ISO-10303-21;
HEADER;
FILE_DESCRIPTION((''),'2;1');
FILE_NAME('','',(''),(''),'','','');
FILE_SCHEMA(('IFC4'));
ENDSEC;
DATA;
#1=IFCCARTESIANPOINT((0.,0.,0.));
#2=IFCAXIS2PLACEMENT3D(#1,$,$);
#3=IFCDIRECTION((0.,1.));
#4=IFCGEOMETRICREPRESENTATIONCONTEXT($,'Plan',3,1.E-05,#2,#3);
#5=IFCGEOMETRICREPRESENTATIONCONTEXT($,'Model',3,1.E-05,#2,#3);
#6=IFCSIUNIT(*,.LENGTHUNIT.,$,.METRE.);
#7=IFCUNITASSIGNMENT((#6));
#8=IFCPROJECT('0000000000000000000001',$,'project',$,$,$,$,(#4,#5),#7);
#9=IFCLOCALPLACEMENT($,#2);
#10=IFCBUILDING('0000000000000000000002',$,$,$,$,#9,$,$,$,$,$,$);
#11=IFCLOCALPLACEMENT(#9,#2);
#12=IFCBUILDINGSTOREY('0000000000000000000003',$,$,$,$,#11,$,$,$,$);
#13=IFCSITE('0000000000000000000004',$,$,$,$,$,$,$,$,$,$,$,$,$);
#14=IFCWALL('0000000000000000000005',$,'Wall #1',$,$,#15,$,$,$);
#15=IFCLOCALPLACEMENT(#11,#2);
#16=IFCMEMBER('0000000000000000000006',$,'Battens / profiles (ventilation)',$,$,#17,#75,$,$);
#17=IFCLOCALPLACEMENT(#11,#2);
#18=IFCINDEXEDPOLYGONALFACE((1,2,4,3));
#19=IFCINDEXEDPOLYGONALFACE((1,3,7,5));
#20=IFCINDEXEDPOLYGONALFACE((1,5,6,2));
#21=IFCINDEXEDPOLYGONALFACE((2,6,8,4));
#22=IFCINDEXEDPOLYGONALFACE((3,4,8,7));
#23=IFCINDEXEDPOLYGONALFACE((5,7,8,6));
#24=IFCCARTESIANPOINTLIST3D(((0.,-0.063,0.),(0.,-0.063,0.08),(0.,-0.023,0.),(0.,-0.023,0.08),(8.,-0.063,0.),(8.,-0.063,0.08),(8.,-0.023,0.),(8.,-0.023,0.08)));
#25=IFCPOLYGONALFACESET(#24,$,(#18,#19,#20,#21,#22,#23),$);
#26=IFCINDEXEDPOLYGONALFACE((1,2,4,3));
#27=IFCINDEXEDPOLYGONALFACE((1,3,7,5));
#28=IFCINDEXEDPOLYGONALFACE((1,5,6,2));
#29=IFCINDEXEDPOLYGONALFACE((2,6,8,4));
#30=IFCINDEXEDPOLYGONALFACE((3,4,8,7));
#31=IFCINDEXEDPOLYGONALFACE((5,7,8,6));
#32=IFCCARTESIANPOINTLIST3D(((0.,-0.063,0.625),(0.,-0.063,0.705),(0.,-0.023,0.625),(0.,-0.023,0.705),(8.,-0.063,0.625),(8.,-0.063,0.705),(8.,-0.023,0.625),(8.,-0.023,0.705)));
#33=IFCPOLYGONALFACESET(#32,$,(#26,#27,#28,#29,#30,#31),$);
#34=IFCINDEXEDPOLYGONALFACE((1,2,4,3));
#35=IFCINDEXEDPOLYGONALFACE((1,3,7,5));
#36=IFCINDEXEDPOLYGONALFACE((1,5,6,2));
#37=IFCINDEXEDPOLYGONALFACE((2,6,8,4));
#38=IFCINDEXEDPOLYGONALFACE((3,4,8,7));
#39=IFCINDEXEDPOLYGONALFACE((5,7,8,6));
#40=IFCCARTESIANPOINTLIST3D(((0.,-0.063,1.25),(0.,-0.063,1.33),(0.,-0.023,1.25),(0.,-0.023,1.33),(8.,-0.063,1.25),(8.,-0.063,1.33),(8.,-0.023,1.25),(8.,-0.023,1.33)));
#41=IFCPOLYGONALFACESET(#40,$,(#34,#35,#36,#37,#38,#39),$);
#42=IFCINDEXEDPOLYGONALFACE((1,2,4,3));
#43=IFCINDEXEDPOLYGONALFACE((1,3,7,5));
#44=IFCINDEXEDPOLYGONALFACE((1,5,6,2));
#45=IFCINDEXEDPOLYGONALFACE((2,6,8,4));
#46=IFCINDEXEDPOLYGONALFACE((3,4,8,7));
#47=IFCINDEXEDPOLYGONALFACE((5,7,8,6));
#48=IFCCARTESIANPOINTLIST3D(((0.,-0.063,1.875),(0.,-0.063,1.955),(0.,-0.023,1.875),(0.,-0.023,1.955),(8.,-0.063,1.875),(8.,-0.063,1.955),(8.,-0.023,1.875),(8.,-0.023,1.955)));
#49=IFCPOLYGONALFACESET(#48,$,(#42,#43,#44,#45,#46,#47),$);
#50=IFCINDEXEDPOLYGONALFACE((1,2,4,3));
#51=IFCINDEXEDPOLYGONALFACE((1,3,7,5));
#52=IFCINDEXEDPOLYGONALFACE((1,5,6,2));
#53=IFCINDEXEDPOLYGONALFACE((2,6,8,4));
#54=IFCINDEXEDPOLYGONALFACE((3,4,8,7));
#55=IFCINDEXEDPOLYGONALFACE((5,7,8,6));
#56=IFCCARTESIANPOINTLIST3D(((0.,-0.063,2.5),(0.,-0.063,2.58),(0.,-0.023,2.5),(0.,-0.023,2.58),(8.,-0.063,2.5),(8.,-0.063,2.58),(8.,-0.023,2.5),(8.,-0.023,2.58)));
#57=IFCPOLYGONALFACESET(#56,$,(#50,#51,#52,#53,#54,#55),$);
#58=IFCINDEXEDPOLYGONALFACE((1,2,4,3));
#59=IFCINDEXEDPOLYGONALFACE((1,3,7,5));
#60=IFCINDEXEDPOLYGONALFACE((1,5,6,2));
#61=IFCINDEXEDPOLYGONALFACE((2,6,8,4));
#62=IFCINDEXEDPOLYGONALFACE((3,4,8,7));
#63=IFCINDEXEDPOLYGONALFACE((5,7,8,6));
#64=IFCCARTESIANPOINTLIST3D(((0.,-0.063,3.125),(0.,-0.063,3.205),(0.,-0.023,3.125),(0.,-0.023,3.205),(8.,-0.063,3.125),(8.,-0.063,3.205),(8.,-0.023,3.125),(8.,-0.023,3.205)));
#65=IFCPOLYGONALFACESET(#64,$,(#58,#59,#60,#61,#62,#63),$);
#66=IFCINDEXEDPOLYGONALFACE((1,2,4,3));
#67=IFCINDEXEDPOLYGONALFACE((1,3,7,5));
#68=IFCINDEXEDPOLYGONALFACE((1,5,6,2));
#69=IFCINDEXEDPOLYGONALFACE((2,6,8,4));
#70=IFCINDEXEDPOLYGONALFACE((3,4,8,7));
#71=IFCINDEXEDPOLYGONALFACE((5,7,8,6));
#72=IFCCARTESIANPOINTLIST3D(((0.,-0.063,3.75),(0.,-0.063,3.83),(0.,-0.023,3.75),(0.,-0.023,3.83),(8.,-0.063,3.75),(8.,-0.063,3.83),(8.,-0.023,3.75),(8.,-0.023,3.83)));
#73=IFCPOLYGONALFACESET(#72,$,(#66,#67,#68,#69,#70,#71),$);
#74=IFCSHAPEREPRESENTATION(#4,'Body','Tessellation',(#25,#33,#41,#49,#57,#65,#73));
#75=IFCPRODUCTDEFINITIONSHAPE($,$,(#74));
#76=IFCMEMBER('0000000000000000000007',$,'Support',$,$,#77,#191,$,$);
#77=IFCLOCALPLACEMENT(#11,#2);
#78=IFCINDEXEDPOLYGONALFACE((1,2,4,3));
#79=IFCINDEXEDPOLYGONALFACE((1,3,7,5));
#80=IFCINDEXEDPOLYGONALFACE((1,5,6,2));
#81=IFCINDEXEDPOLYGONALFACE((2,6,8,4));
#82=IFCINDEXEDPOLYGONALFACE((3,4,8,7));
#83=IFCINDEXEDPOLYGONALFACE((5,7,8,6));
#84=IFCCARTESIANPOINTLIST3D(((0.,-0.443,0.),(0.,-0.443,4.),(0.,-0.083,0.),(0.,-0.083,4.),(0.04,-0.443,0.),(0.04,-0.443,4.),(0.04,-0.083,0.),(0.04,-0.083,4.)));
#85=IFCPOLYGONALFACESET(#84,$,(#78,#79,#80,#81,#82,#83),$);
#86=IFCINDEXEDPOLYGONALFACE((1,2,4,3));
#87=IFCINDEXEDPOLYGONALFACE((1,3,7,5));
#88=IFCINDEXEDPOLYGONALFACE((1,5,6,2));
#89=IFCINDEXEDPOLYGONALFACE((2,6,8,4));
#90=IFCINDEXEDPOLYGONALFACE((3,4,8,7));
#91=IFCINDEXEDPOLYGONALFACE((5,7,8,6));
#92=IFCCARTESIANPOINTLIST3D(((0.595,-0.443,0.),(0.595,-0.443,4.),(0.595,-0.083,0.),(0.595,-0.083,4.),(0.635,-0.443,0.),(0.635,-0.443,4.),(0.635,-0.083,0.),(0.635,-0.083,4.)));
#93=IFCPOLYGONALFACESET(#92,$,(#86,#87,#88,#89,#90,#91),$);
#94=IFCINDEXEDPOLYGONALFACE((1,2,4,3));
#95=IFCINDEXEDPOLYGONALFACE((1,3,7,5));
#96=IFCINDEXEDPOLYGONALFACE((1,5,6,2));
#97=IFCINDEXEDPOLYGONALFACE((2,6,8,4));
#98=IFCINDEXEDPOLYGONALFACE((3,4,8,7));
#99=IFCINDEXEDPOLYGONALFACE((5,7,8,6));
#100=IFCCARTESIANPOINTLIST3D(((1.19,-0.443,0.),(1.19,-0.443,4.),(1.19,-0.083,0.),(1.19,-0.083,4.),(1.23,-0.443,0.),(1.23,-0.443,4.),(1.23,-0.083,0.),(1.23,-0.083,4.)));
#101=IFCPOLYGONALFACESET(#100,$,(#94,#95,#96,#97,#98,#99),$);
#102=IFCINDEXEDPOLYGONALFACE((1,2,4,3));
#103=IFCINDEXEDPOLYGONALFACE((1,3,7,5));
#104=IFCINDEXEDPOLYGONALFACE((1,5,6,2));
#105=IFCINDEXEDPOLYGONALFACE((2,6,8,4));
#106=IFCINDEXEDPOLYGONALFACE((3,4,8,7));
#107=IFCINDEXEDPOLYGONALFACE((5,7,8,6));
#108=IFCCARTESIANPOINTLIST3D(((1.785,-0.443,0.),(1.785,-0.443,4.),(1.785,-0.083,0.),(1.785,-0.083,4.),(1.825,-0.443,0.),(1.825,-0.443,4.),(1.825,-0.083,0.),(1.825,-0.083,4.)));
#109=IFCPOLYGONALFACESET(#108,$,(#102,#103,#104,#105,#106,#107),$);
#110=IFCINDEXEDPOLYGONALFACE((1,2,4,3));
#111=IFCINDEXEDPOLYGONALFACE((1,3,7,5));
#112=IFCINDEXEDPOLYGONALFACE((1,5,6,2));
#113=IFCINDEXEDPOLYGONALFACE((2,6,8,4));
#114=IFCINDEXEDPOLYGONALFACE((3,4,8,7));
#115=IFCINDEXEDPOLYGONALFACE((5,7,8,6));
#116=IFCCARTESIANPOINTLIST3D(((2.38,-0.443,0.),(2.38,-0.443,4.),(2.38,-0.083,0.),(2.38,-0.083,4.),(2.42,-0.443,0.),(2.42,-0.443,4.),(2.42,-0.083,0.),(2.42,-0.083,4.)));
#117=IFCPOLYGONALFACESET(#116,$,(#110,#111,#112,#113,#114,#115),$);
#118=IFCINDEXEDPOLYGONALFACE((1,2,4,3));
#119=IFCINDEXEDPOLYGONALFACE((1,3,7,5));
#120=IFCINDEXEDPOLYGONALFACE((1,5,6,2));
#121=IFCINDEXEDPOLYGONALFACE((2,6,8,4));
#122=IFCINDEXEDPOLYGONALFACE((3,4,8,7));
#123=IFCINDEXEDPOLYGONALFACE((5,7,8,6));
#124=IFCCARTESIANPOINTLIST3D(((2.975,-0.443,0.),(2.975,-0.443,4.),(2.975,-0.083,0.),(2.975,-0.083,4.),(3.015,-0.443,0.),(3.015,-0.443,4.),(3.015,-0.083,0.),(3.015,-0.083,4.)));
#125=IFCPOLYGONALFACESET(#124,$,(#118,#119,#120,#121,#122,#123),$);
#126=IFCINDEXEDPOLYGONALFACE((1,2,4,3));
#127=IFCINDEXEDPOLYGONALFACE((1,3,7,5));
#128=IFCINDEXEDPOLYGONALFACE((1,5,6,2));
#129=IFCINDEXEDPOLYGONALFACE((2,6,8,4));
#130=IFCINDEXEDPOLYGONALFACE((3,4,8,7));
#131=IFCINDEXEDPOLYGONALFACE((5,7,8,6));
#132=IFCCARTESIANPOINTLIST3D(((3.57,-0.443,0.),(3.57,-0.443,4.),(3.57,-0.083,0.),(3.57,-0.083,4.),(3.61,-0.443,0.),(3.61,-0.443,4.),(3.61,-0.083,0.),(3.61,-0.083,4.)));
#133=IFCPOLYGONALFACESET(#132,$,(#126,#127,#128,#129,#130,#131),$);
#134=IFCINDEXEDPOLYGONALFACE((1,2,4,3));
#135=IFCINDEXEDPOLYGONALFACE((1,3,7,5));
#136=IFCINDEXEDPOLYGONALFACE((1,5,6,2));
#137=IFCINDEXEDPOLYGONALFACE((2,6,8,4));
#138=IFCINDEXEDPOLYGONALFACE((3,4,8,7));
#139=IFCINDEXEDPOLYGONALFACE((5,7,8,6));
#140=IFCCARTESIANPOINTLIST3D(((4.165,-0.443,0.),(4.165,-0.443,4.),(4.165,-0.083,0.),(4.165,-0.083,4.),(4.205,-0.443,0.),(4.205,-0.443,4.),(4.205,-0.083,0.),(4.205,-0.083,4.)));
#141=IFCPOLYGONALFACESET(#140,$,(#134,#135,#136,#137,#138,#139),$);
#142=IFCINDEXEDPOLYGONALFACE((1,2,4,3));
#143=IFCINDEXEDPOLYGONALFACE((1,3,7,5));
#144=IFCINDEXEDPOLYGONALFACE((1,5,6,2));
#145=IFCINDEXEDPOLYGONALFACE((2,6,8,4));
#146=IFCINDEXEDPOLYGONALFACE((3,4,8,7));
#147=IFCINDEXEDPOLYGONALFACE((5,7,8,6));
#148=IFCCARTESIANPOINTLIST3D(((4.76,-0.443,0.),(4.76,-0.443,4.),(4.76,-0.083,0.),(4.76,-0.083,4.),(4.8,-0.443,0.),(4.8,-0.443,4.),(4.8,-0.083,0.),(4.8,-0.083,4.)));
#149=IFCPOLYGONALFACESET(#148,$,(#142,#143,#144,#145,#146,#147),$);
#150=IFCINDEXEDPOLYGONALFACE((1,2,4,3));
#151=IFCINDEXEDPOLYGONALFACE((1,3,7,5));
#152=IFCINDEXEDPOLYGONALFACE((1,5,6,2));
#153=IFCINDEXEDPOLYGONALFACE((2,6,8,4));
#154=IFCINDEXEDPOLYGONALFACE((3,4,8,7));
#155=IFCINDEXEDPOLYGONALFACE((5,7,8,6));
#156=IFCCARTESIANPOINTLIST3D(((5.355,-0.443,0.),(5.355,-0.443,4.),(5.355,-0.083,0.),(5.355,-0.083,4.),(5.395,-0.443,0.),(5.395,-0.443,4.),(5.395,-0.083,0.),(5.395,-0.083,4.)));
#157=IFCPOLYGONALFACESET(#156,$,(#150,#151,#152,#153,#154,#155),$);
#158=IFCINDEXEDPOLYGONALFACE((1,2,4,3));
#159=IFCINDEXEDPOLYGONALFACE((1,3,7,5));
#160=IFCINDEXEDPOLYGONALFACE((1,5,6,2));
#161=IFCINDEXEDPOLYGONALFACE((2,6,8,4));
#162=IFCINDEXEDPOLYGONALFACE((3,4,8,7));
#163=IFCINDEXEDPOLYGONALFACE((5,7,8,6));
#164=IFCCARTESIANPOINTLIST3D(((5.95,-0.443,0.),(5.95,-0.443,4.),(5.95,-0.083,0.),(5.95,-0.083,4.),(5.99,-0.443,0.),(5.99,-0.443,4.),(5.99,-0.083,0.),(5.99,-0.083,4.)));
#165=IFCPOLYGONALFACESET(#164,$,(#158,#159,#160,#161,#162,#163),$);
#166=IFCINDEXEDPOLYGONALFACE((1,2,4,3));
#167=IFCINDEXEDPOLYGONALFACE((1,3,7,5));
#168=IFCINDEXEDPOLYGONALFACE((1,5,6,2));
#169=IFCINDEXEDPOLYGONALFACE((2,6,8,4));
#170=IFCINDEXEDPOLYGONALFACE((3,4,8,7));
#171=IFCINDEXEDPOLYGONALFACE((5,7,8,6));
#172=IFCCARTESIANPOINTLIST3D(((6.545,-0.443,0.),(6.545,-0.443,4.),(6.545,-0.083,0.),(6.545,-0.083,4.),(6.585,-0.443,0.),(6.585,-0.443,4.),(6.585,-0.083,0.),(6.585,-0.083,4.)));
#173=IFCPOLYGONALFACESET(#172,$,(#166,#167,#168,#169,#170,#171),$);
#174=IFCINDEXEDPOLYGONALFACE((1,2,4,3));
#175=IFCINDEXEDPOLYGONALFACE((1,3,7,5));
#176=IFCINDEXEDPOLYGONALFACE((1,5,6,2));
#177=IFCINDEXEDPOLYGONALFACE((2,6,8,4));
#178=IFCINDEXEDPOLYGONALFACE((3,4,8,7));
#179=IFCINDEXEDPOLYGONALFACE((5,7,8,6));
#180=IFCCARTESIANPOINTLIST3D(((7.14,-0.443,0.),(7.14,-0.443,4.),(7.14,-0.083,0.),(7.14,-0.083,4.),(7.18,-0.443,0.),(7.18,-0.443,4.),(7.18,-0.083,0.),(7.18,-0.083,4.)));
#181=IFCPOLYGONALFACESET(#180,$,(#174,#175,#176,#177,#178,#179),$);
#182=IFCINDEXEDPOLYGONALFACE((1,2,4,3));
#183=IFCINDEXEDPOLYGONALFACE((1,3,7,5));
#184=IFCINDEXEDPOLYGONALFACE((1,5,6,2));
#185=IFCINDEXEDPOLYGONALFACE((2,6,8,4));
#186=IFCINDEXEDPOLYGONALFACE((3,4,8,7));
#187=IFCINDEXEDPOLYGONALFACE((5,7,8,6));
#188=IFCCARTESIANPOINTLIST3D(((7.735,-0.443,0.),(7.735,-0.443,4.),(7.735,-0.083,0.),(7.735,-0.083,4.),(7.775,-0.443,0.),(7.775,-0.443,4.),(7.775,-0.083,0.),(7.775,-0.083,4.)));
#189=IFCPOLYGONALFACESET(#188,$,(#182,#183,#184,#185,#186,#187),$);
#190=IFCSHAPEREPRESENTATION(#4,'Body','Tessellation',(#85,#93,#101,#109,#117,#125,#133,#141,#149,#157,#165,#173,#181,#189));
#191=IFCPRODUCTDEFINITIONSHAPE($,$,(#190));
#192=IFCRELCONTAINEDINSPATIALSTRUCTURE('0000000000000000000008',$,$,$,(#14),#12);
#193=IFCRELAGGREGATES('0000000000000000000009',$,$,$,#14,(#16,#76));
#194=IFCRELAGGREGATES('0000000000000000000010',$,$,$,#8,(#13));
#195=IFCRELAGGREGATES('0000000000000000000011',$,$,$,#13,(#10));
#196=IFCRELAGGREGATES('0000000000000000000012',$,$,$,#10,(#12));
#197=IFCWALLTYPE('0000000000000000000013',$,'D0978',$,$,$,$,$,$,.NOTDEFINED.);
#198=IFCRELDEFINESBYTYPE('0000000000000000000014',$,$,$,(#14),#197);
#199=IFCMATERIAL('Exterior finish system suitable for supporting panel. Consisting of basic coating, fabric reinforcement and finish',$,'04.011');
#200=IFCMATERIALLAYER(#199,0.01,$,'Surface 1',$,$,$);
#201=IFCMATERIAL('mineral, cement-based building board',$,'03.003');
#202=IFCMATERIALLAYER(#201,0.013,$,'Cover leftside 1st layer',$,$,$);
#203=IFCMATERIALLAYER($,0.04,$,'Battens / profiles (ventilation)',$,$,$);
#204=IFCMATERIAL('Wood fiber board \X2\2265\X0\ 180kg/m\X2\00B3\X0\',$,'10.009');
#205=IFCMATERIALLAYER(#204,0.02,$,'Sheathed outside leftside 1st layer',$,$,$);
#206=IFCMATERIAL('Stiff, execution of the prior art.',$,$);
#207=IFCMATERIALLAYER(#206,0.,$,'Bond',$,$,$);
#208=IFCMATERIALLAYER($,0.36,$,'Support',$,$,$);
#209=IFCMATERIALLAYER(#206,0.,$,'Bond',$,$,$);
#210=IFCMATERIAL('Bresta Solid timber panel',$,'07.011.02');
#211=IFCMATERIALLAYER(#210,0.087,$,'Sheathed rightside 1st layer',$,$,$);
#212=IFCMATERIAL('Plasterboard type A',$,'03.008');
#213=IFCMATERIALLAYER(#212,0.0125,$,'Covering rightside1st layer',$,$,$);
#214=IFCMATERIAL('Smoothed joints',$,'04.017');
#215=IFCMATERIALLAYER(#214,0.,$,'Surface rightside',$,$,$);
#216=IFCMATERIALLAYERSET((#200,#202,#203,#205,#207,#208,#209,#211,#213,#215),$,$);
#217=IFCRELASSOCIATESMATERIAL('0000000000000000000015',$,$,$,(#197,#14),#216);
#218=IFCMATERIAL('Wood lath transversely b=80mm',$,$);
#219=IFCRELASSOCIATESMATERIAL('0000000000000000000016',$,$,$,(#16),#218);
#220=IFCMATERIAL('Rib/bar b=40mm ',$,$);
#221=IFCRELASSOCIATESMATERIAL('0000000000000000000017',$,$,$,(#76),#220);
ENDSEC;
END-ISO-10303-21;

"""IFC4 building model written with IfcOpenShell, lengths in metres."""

from ifc_helpers import new_model, si_unit, direction, frame, frame_2d, origin, place, context, project, spatial, rectangle, extrude, material, layer, layer_set, type_object, element, aggregate, save


model = new_model("IFC4")

# Units and contexts
plan_context = context("Plan", 3, precision=1e-05, world=origin(), true_north=direction((0.0, 1.0)))
model_context = context("Model", 3, precision=1e-05, world=origin(), true_north=direction((0.0, 1.0)))
ifc_project = project(units=[si_unit("LENGTHUNIT", "METRE")], contexts=[plan_context, model_context])

# Site, building, storey
site = spatial("IfcSite", under=ifc_project)
building_placement = place(None, origin())
building = spatial("IfcBuilding", under=site, at=building_placement)
storey_placement = place(building_placement, origin())
storey = spatial("IfcBuildingStorey", under=building, at=storey_placement)

# Wall, members
ifc_material_1 = material(Name="Exterior finish system suitable for supporting panel. Consisting of basic coating, fabric reinforcement and finish", Category="04.011")
ifc_layer_1 = layer(ifc_material_1, 0.01, Name="Surface 1")
ifc_material_2 = material(Name="mineral, cement-based building board", Category="03.003")
ifc_layer_2 = layer(ifc_material_2, 0.013, Name="Cover leftside 1st layer")
ifc_layer_3 = layer(None, 0.04, Name="Battens / profiles (ventilation)")
ifc_material_3 = material(Name="Wood fiber board ≥ 180kg/m³", Category="10.009")
ifc_layer_4 = layer(ifc_material_3, 0.02, Name="Sheathed outside leftside 1st layer")
ifc_material_4 = material(Name="Stiff, execution of the prior art.")
ifc_layer_5 = layer(ifc_material_4, 0.0, Name="Bond")
ifc_layer_6 = layer(None, 0.36, Name="Support")
ifc_layer_7 = layer(ifc_material_4, 0.0, Name="Bond")
ifc_material_5 = material(Name="Bresta Solid timber panel", Category="07.011.02")
ifc_layer_8 = layer(ifc_material_5, 0.087, Name="Sheathed rightside 1st layer")
ifc_material_6 = material(Name="Plasterboard type A", Category="03.008")
ifc_layer_9 = layer(ifc_material_6, 0.0125, Name="Covering rightside1st layer")
ifc_material_7 = material(Name="Smoothed joints", Category="04.017")
ifc_layer_10 = layer(ifc_material_7, 0.0, Name="Surface rightside")
ifc_layer_set = layer_set([ifc_layer_1, ifc_layer_2, ifc_layer_3, ifc_layer_4, ifc_layer_5, ifc_layer_6, ifc_layer_7, ifc_layer_8, ifc_layer_9, ifc_layer_10])
wall_type = type_object("IfcWallType", Name="D0978", PredefinedType="NOTDEFINED", material=ifc_layer_set)
wall_placement = place(None, frame((0.0, 0.0, 0.0), z_axis=(0.0, -1.0, 0.0), x_axis=(1.0, 0.0, 0.0)))
wall = element("IfcWall", 1, at=wall_placement, inside=storey, type_object=wall_type, material=ifc_layer_set, Name="Wall #1")
ifc_material_8 = material(Name="Wood lath transversely b=80mm")
member_1_placement = place(wall_placement, origin())
member_1 = element("IfcMember", 2, at=member_1_placement, material=ifc_material_8, Name="Battens / profiles (ventilation)", context=plan_context, shape_type="SweptSolid", body=[
    extrude(rectangle(XDim=0.08, YDim=0.04, at=frame_2d((0.04, 0.02), x_axis=(1.0, 0.0))), frame((0.0, 0.0, 0.023), z_axis=(1.0, 0.0, 0.0), x_axis=(0.0, 1.0, 0.0)), (0.0, 0.0, 1.0), 8.0),
    extrude(rectangle(XDim=0.08, YDim=0.04, at=frame_2d((0.04, 0.02), x_axis=(1.0, 0.0))), frame((0.0, 0.625, 0.023), z_axis=(1.0, 0.0, 0.0), x_axis=(0.0, 1.0, 0.0)), (0.0, 0.0, 1.0), 8.0),
    extrude(rectangle(XDim=0.08, YDim=0.04, at=frame_2d((0.04, 0.02), x_axis=(1.0, 0.0))), frame((0.0, 1.25, 0.023), z_axis=(1.0, 0.0, 0.0), x_axis=(0.0, 1.0, 0.0)), (0.0, 0.0, 1.0), 8.0),
    extrude(rectangle(XDim=0.08, YDim=0.04, at=frame_2d((0.04, 0.02), x_axis=(1.0, 0.0))), frame((0.0, 1.875, 0.023), z_axis=(1.0, 0.0, 0.0), x_axis=(0.0, 1.0, 0.0)), (0.0, 0.0, 1.0), 8.0),
    extrude(rectangle(XDim=0.08, YDim=0.04, at=frame_2d((0.04, 0.02), x_axis=(1.0, 0.0))), frame((0.0, 2.5, 0.023), z_axis=(1.0, 0.0, 0.0), x_axis=(0.0, 1.0, 0.0)), (0.0, 0.0, 1.0), 8.0),
    extrude(rectangle(XDim=0.08, YDim=0.04, at=frame_2d((0.04, 0.02), x_axis=(1.0, 0.0))), frame((0.0, 3.125, 0.023), z_axis=(1.0, 0.0, 0.0), x_axis=(0.0, 1.0, 0.0)), (0.0, 0.0, 1.0), 8.0),
    extrude(rectangle(XDim=0.08, YDim=0.04, at=frame_2d((0.04, 0.02), x_axis=(1.0, 0.0))), frame((0.0, 3.75, 0.023), z_axis=(1.0, 0.0, 0.0), x_axis=(0.0, 1.0, 0.0)), (0.0, 0.0, 1.0), 8.0),
])
ifc_material_9 = material(Name="Rib/bar b=40mm ")
member_2_placement = place(wall_placement, origin())
member_2 = element("IfcMember", 3, at=member_2_placement, material=ifc_material_9, Name="Support", context=plan_context, shape_type="SweptSolid", body=[
    extrude(rectangle(XDim=0.04, YDim=0.36, at=frame_2d((0.02, 0.18), x_axis=(1.0, 0.0))), frame((0.0, 4.0, 0.083), z_axis=(0.0, -1.0, 0.0), x_axis=(1.0, 0.0, 0.0)), (0.0, 0.0, 1.0), 4.0),
    extrude(rectangle(XDim=0.04, YDim=0.36, at=frame_2d((0.02, 0.18), x_axis=(1.0, 0.0))), frame((0.595, 4.0, 0.083), z_axis=(0.0, -1.0, 0.0), x_axis=(1.0, 0.0, 0.0)), (0.0, 0.0, 1.0), 4.0),
    extrude(rectangle(XDim=0.04, YDim=0.36, at=frame_2d((0.02, 0.18), x_axis=(1.0, 0.0))), frame((1.19, 4.0, 0.083), z_axis=(0.0, -1.0, 0.0), x_axis=(1.0, 0.0, 0.0)), (0.0, 0.0, 1.0), 4.0),
    extrude(rectangle(XDim=0.04, YDim=0.36, at=frame_2d((0.02, 0.18), x_axis=(1.0, 0.0))), frame((1.785, 4.0, 0.083), z_axis=(0.0, -1.0, 0.0), x_axis=(1.0, 0.0, 0.0)), (0.0, 0.0, 1.0), 4.0),
    extrude(rectangle(XDim=0.04, YDim=0.36, at=frame_2d((0.02, 0.18), x_axis=(1.0, 0.0))), frame((2.38, 4.0, 0.083), z_axis=(0.0, -1.0, 0.0), x_axis=(1.0, 0.0, 0.0)), (0.0, 0.0, 1.0), 4.0),
    extrude(rectangle(XDim=0.04, YDim=0.36, at=frame_2d((0.02, 0.18), x_axis=(1.0, 0.0))), frame((2.975, 4.0, 0.083), z_axis=(0.0, -1.0, 0.0), x_axis=(1.0, 0.0, 0.0)), (0.0, 0.0, 1.0), 4.0),
    extrude(rectangle(XDim=0.04, YDim=0.36, at=frame_2d((0.02, 0.18), x_axis=(1.0, 0.0))), frame((3.57, 4.0, 0.083), z_axis=(0.0, -1.0, 0.0), x_axis=(1.0, 0.0, 0.0)), (0.0, 0.0, 1.0), 4.0),
    extrude(rectangle(XDim=0.04, YDim=0.36, at=frame_2d((0.02, 0.18), x_axis=(1.0, 0.0))), frame((4.165, 4.0, 0.083), z_axis=(0.0, -1.0, 0.0), x_axis=(1.0, 0.0, 0.0)), (0.0, 0.0, 1.0), 4.0),
    extrude(rectangle(XDim=0.04, YDim=0.36, at=frame_2d((0.02, 0.18), x_axis=(1.0, 0.0))), frame((4.76, 4.0, 0.083), z_axis=(0.0, -1.0, 0.0), x_axis=(1.0, 0.0, 0.0)), (0.0, 0.0, 1.0), 4.0),
    extrude(rectangle(XDim=0.04, YDim=0.36, at=frame_2d((0.02, 0.18), x_axis=(1.0, 0.0))), frame((5.355, 4.0, 0.083), z_axis=(0.0, -1.0, 0.0), x_axis=(1.0, 0.0, 0.0)), (0.0, 0.0, 1.0), 4.0),
    extrude(rectangle(XDim=0.04, YDim=0.36, at=frame_2d((0.02, 0.18), x_axis=(1.0, 0.0))), frame((5.95, 4.0, 0.083), z_axis=(0.0, -1.0, 0.0), x_axis=(1.0, 0.0, 0.0)), (0.0, 0.0, 1.0), 4.0),
    extrude(rectangle(XDim=0.04, YDim=0.36, at=frame_2d((0.02, 0.18), x_axis=(1.0, 0.0))), frame((6.545, 4.0, 0.083), z_axis=(0.0, -1.0, 0.0), x_axis=(1.0, 0.0, 0.0)), (0.0, 0.0, 1.0), 4.0),
    extrude(rectangle(XDim=0.04, YDim=0.36, at=frame_2d((0.02, 0.18), x_axis=(1.0, 0.0))), frame((7.14, 4.0, 0.083), z_axis=(0.0, -1.0, 0.0), x_axis=(1.0, 0.0, 0.0)), (0.0, 0.0, 1.0), 4.0),
    extrude(rectangle(XDim=0.04, YDim=0.36, at=frame_2d((0.02, 0.18), x_axis=(1.0, 0.0))), frame((7.735, 4.0, 0.083), z_axis=(0.0, -1.0, 0.0), x_axis=(1.0, 0.0, 0.0)), (0.0, 0.0, 1.0), 4.0),
])
aggregate(wall, [member_1, member_2])

save(model, "model.ifc")
